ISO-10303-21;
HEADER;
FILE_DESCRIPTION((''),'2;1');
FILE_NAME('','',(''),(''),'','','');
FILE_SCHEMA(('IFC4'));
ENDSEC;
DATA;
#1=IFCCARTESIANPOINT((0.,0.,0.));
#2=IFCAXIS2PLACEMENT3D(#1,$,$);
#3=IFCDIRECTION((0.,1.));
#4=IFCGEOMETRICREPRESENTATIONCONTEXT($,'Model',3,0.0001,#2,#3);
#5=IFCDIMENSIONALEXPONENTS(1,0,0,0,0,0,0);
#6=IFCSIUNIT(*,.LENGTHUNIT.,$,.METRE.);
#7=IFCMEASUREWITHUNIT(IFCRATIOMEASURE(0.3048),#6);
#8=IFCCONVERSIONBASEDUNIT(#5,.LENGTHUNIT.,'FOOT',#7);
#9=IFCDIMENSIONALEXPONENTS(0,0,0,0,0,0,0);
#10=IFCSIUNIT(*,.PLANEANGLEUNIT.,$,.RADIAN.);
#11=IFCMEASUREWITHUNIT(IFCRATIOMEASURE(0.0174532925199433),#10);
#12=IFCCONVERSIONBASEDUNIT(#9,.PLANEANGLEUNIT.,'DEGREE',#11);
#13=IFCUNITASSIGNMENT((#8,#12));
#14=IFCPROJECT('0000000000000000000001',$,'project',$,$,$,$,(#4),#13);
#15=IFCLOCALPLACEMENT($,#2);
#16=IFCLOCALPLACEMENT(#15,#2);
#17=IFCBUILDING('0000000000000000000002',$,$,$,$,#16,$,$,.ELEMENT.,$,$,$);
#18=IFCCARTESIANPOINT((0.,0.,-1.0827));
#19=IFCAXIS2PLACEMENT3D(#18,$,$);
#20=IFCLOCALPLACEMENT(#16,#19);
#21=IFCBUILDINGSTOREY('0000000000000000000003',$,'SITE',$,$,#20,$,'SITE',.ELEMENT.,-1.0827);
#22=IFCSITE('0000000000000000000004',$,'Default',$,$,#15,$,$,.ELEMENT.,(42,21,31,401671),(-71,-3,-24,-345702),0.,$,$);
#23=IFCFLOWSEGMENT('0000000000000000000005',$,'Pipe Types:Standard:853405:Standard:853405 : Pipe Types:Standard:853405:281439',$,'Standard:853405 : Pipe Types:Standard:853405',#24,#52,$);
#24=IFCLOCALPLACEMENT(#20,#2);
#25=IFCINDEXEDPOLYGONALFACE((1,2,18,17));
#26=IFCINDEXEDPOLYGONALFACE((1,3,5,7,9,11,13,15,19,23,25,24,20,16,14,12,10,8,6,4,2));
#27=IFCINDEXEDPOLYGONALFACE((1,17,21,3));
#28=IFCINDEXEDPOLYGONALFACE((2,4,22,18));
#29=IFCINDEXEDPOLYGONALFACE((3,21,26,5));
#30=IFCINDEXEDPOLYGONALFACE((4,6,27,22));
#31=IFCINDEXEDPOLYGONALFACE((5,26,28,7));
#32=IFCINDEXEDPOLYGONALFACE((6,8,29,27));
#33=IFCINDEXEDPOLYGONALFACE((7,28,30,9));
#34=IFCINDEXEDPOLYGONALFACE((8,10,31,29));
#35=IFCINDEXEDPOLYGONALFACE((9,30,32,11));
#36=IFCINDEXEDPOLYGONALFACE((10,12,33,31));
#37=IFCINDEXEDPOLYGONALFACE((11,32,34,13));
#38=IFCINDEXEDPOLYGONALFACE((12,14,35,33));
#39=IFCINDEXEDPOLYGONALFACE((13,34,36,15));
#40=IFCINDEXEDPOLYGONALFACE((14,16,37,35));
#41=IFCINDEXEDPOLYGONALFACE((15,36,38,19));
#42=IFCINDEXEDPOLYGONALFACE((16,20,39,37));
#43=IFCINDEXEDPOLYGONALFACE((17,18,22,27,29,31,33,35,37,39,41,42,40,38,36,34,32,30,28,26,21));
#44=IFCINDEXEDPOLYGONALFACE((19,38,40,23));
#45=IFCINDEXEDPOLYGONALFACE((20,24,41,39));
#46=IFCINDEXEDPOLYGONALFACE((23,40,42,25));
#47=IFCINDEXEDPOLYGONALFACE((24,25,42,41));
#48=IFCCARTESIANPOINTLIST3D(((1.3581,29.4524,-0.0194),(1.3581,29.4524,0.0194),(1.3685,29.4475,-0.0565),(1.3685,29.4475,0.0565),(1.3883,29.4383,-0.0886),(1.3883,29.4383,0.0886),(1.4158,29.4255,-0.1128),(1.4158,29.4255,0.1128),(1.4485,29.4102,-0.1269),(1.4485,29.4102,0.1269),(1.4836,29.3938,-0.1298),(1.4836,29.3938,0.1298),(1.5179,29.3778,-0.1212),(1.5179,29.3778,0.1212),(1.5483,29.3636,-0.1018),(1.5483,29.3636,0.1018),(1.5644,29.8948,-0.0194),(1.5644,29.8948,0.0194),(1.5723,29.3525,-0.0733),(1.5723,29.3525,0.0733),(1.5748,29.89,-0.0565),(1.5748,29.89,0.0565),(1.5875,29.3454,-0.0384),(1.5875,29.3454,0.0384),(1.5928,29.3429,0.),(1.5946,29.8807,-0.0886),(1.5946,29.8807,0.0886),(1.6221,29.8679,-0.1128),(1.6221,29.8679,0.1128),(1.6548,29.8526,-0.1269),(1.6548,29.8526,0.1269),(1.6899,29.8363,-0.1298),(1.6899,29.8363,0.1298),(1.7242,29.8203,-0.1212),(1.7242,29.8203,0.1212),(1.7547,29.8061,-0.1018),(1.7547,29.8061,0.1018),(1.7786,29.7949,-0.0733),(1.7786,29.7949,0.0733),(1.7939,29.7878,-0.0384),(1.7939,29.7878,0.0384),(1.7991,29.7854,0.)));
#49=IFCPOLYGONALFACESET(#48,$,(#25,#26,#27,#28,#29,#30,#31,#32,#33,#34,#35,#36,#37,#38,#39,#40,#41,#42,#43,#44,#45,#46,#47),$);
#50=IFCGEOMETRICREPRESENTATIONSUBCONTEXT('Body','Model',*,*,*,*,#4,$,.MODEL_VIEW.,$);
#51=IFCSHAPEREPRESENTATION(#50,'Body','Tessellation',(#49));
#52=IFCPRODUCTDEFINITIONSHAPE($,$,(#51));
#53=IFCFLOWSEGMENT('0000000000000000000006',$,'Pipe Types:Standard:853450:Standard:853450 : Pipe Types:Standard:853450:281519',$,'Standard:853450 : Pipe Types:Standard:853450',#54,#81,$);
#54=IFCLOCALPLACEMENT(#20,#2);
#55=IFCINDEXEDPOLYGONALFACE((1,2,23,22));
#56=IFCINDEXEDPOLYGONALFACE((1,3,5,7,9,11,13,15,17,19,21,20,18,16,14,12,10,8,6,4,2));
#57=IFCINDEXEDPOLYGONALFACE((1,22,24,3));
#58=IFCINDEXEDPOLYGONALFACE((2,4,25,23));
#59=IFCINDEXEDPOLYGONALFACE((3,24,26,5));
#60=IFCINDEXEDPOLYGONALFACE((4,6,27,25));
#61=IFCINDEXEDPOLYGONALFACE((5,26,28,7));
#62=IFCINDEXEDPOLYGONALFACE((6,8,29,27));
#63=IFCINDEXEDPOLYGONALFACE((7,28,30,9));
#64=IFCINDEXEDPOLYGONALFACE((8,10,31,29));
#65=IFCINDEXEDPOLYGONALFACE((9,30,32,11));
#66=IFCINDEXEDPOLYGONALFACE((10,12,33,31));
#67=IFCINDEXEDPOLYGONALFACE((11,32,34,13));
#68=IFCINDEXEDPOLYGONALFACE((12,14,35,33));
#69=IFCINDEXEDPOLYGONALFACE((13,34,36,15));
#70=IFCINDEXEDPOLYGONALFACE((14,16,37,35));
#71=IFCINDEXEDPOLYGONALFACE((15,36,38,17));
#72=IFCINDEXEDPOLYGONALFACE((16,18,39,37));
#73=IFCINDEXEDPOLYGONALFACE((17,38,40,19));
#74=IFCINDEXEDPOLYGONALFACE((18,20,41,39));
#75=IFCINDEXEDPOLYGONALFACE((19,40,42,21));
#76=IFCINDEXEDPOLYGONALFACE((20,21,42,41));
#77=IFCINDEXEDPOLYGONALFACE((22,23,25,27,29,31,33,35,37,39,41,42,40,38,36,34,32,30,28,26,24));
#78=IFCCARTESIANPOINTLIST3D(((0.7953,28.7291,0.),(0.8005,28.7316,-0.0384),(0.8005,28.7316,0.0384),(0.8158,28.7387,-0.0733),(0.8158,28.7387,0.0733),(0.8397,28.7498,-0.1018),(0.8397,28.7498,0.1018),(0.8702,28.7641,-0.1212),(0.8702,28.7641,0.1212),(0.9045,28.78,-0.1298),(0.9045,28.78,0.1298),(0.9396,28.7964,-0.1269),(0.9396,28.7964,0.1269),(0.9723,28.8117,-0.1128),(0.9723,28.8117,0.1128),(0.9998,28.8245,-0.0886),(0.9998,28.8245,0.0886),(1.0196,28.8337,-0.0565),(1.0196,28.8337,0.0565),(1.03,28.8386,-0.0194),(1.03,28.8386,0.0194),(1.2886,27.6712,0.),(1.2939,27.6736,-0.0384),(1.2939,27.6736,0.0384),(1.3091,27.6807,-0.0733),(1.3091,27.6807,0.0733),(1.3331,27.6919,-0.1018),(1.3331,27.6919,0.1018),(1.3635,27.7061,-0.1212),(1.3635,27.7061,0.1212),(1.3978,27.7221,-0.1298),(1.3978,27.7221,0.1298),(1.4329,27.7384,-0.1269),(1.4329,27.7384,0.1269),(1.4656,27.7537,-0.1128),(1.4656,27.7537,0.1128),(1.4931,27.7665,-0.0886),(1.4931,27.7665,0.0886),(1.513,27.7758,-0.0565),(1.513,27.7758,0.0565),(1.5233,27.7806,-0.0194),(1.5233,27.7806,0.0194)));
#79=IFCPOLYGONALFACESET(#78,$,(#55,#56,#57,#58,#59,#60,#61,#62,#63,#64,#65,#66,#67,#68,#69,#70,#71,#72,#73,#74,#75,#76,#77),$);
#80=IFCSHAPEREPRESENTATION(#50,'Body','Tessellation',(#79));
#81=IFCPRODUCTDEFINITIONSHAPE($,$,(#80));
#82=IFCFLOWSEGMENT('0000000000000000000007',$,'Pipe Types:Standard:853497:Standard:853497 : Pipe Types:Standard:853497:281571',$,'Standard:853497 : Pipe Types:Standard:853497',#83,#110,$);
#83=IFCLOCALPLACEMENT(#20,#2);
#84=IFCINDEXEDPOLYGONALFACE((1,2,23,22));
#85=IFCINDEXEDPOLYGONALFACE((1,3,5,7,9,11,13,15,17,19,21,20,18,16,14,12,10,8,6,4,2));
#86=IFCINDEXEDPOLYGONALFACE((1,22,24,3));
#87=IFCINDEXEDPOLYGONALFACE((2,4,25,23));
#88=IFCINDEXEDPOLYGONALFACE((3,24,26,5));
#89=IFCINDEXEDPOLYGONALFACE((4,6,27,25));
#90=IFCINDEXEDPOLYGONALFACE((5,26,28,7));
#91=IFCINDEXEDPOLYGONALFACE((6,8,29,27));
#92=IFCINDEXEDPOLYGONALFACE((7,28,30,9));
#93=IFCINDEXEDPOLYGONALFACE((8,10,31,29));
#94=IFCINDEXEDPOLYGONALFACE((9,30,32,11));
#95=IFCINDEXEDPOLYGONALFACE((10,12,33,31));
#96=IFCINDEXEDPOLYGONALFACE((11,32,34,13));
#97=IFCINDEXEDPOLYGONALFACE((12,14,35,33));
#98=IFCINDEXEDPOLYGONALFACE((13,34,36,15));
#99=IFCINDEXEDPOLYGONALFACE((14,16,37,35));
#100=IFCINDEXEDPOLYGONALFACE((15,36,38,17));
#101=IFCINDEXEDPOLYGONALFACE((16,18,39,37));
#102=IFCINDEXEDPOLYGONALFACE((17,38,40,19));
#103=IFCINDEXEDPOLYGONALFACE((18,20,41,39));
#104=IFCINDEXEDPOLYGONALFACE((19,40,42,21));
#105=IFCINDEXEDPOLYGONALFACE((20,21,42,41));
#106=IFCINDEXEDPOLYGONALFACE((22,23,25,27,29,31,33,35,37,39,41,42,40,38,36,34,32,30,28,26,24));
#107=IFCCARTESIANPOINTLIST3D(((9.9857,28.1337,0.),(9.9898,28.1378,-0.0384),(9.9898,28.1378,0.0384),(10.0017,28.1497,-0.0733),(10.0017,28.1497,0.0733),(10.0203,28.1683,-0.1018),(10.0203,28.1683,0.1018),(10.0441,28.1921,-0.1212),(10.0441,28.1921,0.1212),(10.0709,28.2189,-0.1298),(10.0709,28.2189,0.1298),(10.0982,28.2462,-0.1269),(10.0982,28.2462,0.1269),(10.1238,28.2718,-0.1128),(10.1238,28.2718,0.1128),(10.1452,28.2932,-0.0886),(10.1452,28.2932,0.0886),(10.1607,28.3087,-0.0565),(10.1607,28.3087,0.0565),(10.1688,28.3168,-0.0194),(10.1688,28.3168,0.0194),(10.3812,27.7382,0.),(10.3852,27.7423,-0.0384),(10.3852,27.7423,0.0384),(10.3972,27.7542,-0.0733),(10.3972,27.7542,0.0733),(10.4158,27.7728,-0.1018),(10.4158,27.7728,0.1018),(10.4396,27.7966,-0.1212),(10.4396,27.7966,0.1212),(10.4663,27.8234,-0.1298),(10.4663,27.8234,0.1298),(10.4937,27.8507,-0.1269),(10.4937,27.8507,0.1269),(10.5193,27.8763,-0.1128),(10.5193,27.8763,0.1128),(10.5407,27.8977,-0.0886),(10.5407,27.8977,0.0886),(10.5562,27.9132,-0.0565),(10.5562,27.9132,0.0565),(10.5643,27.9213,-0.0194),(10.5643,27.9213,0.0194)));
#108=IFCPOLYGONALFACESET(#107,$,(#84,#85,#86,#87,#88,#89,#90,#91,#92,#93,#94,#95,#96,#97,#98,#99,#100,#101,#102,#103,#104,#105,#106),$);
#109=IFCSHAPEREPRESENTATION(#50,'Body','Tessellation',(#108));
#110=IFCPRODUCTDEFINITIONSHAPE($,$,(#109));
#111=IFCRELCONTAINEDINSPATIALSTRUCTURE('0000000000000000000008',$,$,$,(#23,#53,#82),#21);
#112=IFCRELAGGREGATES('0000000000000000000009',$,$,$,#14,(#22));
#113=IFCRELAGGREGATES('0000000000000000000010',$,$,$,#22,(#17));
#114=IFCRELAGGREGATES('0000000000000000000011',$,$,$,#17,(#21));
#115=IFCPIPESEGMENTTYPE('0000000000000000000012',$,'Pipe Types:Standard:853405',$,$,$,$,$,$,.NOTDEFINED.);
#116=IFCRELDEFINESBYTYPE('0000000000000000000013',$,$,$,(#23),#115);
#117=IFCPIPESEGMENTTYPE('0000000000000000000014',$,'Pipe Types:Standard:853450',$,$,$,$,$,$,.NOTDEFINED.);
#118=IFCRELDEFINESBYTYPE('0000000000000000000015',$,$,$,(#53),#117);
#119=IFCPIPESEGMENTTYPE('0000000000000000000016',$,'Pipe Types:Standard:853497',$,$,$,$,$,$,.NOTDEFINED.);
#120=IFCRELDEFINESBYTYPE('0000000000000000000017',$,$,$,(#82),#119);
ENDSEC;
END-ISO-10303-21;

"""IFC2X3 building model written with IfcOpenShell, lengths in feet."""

from ifc_helpers import new_model, entity, si_unit, converted_unit, direction, frame, frame_2d, origin, place, context, subcontext, project, spatial, circle, extrude, source, transform, mapped, type_object, type_shapes, element, save


model = new_model("IFC2X3")

# Units and contexts
model_context = context("Model", 3, precision=0.0001, world=origin(), true_north=direction((0.0, 1.0)))
body_context = subcontext(model_context, "Body", "Model", "MODEL_VIEW")
ifc_project = project(units=[converted_unit("LENGTHUNIT", "FOOT", entity("IfcRatioMeasure", 0.3048), si_unit("LENGTHUNIT", "METRE"), dimensions=[1, 0, 0, 0, 0, 0, 0]), converted_unit("PLANEANGLEUNIT", "DEGREE", entity("IfcRatioMeasure", 0.0174532925199433), si_unit("PLANEANGLEUNIT", "RADIAN"), dimensions=[0, 0, 0, 0, 0, 0, 0])], contexts=[model_context])

# Site, building, storey
site_placement = place(None, origin())
site = spatial("IfcSite", under=ifc_project, at=site_placement, Name="Default", CompositionType="ELEMENT", RefLatitude=(42, 21, 31, 401671), RefLongitude=(-71, -3, -24, -345702), RefElevation=0.0)
building_placement = place(site_placement, origin())
building = spatial("IfcBuilding", under=site, at=building_placement, CompositionType="ELEMENT")
storey_placement = place(building_placement, frame((0.0, 0.0, -1.0827)))
storey = spatial("IfcBuildingStorey", under=building, at=storey_placement, Name="SITE", LongName="SITE", CompositionType="ELEMENT", Elevation=-1.0827)

# Flow segments
pipe_segment_type_1 = type_object("IfcPipeSegmentType", Name="Pipe Types:Standard:853405", PredefinedType="NOTDEFINED")
shared_shape_1 = source(origin(), body_context, "Body", "SweptSolid", [
    extrude(circle(Radius=0.1302, at=frame_2d((0.0, 0.0), x_axis=(1.0, 0.0))), frame((1.4748, 29.3979, -1.0827), z_axis=(0.422618, 0.906308, 0.0), x_axis=(0.906308, -0.422618, 0.0)), (0.0, 0.0, 1.0), 0.4882),
])
type_shapes(pipe_segment_type_1, [shared_shape_1])
flow_segment_1_placement = place(storey_placement, frame((0.0, 0.0, 1.0827)))
element("IfcFlowSegment", 1, at=flow_segment_1_placement, inside=storey, type_object=pipe_segment_type_1, Name="Pipe Types:Standard:853405:Standard:853405 : Pipe Types:Standard:853405:281439", ObjectType="Standard:853405 : Pipe Types:Standard:853405", context=body_context, shape_type="MappedRepresentation", body=[
    mapped(shared_shape_1, transform((0.0, 0.0, 0.0), scale=1.0)),
])
pipe_segment_type_2 = type_object("IfcPipeSegmentType", Name="Pipe Types:Standard:853450", PredefinedType="NOTDEFINED")
shared_shape_2 = source(origin(), body_context, "Body", "SweptSolid", [
    extrude(circle(Radius=0.1302, at=frame_2d((0.0, 0.0), x_axis=(1.0, 0.0))), frame((0.9133, 28.7842, -1.0827), z_axis=(0.422618, -0.906308, 0.0), x_axis=(-0.906308, -0.422618, 0.0)), (0.0, 0.0, 1.0), 1.1673),
])
type_shapes(pipe_segment_type_2, [shared_shape_2])
flow_segment_2_placement = place(storey_placement, frame((0.0, 0.0, 1.0827)))
element("IfcFlowSegment", 2, at=flow_segment_2_placement, inside=storey, type_object=pipe_segment_type_2, Name="Pipe Types:Standard:853450:Standard:853450 : Pipe Types:Standard:853450:281519", ObjectType="Standard:853450 : Pipe Types:Standard:853450", context=body_context, shape_type="MappedRepresentation", body=[
    mapped(shared_shape_2, transform((0.0, 0.0, 0.0), scale=1.0)),
])
pipe_segment_type_3 = type_object("IfcPipeSegmentType", Name="Pipe Types:Standard:853497", PredefinedType="NOTDEFINED")
shared_shape_3 = source(origin(), body_context, "Body", "SweptSolid", [
    extrude(circle(Radius=0.1302, at=frame_2d((0.0, 0.0), x_axis=(1.0, 0.0))), frame((10.4732, 27.8302, -1.0827), z_axis=(-0.707107, 0.707107, 0.0), x_axis=(-0.707107, -0.707107, 0.0)), (0.0, 0.0, 1.0), 0.5593),
])
type_shapes(pipe_segment_type_3, [shared_shape_3])
flow_segment_3_placement = place(storey_placement, frame((0.0, 0.0, 1.0827)))
element("IfcFlowSegment", 3, at=flow_segment_3_placement, inside=storey, type_object=pipe_segment_type_3, Name="Pipe Types:Standard:853497:Standard:853497 : Pipe Types:Standard:853497:281571", ObjectType="Standard:853497 : Pipe Types:Standard:853497", context=body_context, shape_type="MappedRepresentation", body=[
    mapped(shared_shape_3, transform((0.0, 0.0, 0.0), scale=1.0)),
])

save(model, "model.ifc")
